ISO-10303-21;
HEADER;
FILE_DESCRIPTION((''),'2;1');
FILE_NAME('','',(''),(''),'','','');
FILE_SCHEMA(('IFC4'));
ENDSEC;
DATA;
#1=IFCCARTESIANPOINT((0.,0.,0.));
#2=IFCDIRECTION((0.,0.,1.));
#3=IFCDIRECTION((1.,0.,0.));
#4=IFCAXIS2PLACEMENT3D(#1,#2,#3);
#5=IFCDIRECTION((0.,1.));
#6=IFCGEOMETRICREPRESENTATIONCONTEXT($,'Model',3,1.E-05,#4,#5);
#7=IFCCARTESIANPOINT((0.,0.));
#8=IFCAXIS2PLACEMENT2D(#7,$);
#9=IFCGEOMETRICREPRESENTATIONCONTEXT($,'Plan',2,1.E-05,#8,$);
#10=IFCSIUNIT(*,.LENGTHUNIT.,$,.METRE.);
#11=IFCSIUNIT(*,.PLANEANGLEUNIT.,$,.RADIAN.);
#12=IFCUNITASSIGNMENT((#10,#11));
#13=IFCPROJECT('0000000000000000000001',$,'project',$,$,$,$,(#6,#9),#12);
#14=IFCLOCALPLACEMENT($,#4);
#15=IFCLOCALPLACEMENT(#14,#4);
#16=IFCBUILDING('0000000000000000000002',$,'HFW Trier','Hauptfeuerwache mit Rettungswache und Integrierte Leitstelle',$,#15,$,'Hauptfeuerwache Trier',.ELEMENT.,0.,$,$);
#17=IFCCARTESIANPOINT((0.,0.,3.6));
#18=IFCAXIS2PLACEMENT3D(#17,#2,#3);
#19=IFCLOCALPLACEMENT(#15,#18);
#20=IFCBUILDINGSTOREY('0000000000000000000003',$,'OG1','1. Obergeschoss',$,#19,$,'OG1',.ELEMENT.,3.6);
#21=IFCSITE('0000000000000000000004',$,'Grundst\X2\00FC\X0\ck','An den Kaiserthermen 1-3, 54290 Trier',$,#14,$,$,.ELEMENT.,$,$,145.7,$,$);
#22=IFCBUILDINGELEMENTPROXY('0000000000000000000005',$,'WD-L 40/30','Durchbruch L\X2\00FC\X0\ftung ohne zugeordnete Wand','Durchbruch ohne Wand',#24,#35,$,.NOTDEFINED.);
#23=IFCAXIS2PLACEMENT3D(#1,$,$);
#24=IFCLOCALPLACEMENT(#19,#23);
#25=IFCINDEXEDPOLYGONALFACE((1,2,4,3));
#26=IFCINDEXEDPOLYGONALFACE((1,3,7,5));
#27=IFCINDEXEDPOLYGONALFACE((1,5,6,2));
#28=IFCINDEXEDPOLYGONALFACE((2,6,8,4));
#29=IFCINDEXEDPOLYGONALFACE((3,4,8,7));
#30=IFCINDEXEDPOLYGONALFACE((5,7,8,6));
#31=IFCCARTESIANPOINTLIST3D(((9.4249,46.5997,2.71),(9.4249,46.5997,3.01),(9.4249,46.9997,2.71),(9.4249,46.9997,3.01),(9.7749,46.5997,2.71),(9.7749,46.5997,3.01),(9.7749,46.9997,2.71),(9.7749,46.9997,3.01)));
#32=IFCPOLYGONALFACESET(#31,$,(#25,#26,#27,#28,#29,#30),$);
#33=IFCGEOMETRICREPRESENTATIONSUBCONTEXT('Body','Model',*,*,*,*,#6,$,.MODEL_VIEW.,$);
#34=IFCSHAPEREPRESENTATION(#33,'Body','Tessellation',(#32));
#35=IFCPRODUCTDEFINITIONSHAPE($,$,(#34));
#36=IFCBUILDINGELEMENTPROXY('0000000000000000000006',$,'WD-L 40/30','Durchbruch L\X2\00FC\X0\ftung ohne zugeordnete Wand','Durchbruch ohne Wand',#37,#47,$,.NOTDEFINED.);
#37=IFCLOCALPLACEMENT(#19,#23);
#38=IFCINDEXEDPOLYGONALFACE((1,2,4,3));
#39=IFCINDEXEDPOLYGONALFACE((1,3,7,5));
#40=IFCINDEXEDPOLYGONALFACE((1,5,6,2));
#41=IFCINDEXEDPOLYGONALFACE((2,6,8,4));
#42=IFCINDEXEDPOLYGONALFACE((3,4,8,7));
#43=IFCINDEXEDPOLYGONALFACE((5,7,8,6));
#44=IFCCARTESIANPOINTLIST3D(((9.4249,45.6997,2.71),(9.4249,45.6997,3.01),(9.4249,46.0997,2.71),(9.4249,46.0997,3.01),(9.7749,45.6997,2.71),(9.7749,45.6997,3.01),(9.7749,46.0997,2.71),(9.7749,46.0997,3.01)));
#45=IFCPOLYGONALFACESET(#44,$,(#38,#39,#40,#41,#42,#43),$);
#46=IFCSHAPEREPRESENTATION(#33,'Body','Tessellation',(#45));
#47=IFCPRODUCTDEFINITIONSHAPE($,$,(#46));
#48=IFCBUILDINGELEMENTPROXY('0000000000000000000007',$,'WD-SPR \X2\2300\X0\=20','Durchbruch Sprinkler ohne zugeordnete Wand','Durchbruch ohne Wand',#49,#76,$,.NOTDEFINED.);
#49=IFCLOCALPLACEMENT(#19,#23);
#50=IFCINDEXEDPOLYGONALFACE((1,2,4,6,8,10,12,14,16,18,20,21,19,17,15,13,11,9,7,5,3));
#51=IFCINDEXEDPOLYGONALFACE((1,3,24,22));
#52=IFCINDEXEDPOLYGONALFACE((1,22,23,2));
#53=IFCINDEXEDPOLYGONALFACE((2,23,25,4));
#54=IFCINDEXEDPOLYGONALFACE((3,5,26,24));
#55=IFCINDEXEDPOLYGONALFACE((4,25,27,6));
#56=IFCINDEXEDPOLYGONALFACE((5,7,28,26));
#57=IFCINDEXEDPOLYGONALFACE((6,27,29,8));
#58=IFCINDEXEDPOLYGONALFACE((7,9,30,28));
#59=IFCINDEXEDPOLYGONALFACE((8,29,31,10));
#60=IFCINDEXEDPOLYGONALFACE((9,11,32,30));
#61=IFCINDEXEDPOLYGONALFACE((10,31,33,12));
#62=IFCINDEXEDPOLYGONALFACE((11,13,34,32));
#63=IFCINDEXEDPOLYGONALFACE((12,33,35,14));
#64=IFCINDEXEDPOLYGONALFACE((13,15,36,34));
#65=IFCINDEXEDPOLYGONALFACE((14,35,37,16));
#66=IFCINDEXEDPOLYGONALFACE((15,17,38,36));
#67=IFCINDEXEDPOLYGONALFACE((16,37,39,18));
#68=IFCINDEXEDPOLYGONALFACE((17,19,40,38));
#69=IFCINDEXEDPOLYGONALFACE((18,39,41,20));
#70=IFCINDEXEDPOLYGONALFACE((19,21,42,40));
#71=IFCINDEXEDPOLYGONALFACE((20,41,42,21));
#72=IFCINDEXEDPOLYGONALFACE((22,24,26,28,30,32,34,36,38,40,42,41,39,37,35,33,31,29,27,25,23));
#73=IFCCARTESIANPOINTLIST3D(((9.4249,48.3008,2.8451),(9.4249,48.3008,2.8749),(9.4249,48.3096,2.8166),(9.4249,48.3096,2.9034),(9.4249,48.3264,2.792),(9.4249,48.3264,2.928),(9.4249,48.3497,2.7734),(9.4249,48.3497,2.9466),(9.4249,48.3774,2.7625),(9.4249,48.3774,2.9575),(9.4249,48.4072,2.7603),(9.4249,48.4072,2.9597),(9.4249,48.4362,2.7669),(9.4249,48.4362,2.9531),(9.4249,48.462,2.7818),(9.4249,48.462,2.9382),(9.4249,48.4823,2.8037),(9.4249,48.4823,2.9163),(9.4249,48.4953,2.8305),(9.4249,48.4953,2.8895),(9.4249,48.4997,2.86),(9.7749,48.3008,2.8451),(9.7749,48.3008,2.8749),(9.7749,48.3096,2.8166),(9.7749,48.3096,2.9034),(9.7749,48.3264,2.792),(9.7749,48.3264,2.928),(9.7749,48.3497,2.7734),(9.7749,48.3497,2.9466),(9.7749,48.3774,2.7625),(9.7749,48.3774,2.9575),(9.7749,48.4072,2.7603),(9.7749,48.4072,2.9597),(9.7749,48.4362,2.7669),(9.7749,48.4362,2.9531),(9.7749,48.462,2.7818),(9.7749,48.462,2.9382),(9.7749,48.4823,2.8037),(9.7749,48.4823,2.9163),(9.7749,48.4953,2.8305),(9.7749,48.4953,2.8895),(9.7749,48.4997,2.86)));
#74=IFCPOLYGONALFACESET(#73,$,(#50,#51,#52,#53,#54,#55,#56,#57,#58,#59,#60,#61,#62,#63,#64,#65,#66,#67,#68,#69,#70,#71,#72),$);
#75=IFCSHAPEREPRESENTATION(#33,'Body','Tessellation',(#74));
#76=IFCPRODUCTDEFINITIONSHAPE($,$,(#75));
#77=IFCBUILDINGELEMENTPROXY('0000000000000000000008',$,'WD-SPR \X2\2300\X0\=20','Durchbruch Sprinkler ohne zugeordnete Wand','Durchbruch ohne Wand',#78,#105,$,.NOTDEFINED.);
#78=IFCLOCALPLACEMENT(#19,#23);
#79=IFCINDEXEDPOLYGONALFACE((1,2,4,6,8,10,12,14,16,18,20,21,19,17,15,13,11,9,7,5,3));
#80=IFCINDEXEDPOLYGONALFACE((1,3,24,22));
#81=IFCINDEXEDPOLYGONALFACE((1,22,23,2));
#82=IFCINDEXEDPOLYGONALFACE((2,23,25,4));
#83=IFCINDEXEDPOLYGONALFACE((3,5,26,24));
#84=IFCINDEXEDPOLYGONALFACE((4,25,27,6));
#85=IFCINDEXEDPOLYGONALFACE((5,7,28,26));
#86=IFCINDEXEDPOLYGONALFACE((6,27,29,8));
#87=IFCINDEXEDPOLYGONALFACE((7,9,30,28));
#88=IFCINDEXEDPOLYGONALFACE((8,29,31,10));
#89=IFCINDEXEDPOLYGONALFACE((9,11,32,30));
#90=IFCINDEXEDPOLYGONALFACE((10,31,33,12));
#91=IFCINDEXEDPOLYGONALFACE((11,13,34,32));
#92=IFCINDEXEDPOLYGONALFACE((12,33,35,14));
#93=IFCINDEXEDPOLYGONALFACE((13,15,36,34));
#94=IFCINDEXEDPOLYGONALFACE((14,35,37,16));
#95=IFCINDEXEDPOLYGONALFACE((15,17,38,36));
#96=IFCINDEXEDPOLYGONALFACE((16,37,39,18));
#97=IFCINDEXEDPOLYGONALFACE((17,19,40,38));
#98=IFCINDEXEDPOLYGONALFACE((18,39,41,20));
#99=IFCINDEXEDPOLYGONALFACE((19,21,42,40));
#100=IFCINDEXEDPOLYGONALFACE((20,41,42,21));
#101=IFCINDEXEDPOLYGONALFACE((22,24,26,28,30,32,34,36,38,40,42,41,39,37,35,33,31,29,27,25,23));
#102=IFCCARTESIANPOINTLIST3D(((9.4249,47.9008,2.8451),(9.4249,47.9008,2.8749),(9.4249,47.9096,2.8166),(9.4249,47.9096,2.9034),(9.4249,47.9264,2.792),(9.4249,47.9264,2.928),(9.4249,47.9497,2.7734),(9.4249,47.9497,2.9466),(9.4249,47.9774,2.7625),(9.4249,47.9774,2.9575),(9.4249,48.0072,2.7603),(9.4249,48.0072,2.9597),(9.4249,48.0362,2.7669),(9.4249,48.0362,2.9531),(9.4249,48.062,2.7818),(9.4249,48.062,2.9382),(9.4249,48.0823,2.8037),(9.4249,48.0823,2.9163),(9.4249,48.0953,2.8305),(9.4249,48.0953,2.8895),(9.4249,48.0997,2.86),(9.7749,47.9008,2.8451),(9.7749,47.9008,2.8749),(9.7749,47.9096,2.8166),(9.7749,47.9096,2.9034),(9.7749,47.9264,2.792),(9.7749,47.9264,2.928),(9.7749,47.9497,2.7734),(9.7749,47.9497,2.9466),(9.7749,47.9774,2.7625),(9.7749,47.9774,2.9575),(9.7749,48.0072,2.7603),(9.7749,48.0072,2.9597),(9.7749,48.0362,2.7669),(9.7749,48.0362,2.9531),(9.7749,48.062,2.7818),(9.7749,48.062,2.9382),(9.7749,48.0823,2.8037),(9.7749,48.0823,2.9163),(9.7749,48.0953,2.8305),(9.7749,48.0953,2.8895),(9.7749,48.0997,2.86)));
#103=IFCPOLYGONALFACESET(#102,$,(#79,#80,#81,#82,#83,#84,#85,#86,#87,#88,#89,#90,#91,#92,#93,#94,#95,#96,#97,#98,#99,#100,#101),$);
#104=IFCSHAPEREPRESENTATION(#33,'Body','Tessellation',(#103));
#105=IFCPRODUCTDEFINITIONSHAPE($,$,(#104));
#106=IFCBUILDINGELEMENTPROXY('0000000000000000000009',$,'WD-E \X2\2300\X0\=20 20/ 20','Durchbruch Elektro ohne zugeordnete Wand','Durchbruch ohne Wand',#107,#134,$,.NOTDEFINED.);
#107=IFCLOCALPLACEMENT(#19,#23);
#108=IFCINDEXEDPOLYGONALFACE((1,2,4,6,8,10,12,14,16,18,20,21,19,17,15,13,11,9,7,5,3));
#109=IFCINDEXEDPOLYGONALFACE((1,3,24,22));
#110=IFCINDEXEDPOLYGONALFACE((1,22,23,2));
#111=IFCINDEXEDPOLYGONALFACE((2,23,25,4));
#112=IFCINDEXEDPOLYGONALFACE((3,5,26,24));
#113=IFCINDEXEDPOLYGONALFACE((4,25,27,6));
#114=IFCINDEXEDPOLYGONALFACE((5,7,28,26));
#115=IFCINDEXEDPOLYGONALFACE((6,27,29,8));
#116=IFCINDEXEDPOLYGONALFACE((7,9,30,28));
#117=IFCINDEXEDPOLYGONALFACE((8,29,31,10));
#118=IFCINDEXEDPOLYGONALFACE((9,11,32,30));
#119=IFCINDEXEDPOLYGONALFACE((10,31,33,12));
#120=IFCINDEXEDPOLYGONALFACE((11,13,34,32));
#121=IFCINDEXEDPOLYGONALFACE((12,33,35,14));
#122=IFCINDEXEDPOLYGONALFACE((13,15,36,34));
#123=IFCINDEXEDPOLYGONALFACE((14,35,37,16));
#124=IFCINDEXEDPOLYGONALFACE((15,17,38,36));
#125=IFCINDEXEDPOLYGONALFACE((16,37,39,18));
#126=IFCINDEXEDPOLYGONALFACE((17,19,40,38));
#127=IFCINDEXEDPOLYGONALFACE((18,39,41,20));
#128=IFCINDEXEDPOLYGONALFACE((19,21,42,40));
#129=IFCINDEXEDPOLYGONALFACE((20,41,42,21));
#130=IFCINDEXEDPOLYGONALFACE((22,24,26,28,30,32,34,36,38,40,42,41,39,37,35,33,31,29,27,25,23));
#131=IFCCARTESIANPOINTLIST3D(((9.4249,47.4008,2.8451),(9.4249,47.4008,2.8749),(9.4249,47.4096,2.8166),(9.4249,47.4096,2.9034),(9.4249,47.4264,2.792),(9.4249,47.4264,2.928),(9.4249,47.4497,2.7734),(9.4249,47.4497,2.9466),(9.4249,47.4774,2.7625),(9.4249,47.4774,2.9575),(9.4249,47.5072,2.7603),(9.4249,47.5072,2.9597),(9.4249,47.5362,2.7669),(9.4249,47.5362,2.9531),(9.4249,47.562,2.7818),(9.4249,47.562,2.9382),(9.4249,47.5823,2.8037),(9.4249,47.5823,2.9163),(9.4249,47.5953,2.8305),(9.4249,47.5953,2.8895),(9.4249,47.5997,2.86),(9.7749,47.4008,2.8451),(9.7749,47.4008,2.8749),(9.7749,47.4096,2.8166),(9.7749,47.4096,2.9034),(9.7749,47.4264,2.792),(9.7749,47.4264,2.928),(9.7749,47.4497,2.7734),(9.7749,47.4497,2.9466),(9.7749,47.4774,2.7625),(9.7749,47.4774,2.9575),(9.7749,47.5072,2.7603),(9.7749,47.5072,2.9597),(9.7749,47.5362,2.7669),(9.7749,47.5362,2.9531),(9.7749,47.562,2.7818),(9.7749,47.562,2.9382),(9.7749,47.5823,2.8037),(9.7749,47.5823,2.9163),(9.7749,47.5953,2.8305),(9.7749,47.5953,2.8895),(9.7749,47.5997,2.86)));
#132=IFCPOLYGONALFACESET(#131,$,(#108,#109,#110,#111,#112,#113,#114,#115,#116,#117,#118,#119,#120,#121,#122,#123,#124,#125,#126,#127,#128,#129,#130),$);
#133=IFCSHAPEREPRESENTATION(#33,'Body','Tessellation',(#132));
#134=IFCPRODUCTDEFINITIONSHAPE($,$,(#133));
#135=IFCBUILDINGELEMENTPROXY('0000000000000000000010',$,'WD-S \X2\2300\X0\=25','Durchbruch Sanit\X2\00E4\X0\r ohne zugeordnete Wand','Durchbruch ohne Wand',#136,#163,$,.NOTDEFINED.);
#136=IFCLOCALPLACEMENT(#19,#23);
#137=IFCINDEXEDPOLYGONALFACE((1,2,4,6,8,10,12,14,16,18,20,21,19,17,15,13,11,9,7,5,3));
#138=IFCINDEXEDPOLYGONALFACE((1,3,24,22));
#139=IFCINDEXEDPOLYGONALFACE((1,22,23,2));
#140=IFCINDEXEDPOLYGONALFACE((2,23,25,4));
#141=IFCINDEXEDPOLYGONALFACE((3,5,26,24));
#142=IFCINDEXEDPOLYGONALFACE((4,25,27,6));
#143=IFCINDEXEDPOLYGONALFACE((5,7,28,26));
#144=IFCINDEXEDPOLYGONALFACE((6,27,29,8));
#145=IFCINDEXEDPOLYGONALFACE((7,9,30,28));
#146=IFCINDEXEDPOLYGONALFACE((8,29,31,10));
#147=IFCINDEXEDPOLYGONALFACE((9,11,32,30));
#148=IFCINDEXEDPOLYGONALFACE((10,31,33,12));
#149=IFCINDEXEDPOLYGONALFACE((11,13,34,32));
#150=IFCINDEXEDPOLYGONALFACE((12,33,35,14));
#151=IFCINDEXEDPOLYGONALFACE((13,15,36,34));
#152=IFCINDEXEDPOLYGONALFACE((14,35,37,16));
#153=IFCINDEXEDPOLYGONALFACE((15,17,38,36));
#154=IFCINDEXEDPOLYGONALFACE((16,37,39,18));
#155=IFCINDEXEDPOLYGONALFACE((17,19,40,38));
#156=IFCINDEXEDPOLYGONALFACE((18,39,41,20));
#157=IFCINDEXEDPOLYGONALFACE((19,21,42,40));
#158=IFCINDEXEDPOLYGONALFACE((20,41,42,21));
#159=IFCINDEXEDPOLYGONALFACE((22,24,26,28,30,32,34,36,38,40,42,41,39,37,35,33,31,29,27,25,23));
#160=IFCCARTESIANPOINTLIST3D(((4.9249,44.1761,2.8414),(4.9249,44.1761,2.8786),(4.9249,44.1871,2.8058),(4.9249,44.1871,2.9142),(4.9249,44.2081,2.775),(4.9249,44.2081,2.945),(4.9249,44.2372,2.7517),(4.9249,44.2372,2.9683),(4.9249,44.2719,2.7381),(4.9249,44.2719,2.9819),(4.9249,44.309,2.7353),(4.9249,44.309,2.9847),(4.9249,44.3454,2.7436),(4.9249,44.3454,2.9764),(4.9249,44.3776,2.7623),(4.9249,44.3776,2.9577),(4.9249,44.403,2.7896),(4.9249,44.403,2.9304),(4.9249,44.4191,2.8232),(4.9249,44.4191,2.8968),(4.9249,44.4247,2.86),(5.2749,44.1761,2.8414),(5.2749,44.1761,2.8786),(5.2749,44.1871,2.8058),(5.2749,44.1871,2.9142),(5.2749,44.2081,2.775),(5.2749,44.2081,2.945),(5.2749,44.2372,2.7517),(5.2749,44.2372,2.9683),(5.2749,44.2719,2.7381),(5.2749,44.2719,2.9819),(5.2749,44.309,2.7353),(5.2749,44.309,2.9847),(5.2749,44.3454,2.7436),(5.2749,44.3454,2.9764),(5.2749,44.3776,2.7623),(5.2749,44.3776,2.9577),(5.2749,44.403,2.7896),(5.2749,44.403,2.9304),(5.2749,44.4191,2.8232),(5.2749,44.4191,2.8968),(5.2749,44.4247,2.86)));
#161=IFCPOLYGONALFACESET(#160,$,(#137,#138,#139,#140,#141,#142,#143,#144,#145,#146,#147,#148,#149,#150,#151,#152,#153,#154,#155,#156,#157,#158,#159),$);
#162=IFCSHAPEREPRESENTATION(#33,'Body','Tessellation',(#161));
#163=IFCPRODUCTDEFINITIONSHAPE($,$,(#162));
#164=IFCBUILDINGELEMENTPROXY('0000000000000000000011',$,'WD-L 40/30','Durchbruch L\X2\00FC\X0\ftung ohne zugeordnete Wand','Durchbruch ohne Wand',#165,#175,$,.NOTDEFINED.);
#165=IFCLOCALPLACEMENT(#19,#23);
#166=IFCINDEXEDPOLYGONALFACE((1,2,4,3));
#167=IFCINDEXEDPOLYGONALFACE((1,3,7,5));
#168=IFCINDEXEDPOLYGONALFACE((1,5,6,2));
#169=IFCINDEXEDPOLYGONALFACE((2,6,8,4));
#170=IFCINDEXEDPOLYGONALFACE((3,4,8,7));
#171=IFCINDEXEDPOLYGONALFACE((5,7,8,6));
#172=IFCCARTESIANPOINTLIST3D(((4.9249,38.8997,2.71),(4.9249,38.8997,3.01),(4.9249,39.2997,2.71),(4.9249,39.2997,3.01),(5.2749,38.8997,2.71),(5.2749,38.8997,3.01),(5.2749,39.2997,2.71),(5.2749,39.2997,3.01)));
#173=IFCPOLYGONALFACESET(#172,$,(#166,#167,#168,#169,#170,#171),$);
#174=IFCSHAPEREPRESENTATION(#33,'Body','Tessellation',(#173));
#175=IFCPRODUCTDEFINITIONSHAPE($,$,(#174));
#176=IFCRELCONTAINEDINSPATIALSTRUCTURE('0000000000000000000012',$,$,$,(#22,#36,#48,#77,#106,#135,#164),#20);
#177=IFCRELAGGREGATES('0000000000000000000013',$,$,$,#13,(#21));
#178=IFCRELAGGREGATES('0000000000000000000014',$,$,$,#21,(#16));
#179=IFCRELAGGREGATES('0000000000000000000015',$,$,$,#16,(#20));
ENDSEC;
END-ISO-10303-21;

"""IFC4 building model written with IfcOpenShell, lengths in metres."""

from ifc_helpers import new_model, si_unit, direction, frame, origin_with_axes, origin_2d, place, context, subcontext, project, spatial, rectangle, circle, extrude, element, save


model = new_model("IFC4")

# Units and contexts
model_context = context("Model", 3, precision=1e-05, world=origin_with_axes(), true_north=direction((0.0, 1.0)))
plan_context = context("Plan", 2, precision=1e-05, world=origin_2d())
body_context = subcontext(model_context, "Body", "Model", "MODEL_VIEW")
ifc_project = project(units=[si_unit("LENGTHUNIT", "METRE"), si_unit("PLANEANGLEUNIT", "RADIAN")], contexts=[model_context, plan_context])

# Site, building, storey
site_placement = place(None, origin_with_axes())
site = spatial("IfcSite", under=ifc_project, at=site_placement, Name="Grundstück", Description="An den Kaiserthermen 1-3, 54290 Trier", CompositionType="ELEMENT", RefElevation=145.7)
building_placement = place(site_placement, origin_with_axes())
building = spatial("IfcBuilding", under=site, at=building_placement, Name="HFW Trier", Description="Hauptfeuerwache mit Rettungswache und Integrierte Leitstelle", LongName="Hauptfeuerwache Trier", CompositionType="ELEMENT", ElevationOfRefHeight=0.0)
storey_placement = place(building_placement, frame((0.0, 0.0, 3.6), z_axis=(0.0, 0.0, 1.0), x_axis=(1.0, 0.0, 0.0)))
storey = spatial("IfcBuildingStorey", under=building, at=storey_placement, Name="OG1", Description="1. Obergeschoss", LongName="OG1", CompositionType="ELEMENT", Elevation=3.6)

# Building element proxies
for number, where, z_axis, x_axis, name in (
    (1, (9.5999, 46.7997, 2.71), (0.0, 0.0, 1.0), (0.0, 1.0, 0.0), "WD-L 40/30"),
    (2, (9.5999, 45.8997, 2.71), (0.0, 0.0, 1.0), (0.0, 1.0, 0.0), "WD-L 40/30"),
):
    element("IfcBuildingElementProxy", number, at=place(storey_placement, frame(where, z_axis=z_axis, x_axis=x_axis)), inside=storey, Name=name, Description="Durchbruch Lüftung ohne zugeordnete Wand", ObjectType="Durchbruch ohne Wand", PredefinedType="NOTDEFINED", context=body_context, shape_type="SweptSolid", body=[
        extrude(rectangle(XDim=0.4, YDim=0.35, at=origin_2d()), origin_with_axes(), (0.0, 0.0, 1.0), 0.3),
    ])
for number, where, z_axis, x_axis, name, description in (
    (3, (9.5999, 48.3997, 2.76), (0.0, 0.0, 1.0), (0.0, 1.0, 0.0), "WD-SPR ⌀=20", "Durchbruch Sprinkler ohne zugeordnete Wand"),
    (4, (9.5999, 47.9997, 2.76), (0.0, 0.0, 1.0), (0.0, 1.0, 0.0), "WD-SPR ⌀=20", "Durchbruch Sprinkler ohne zugeordnete Wand"),
    (5, (9.5999, 47.4997, 2.76), (0.0, 0.0, 1.0), (0.0, 1.0, 0.0), "WD-E ⌀=20 20/ 20", "Durchbruch Elektro ohne zugeordnete Wand"),
):
    element("IfcBuildingElementProxy", number, at=place(storey_placement, frame(where, z_axis=z_axis, x_axis=x_axis)), inside=storey, Name=name, Description=description, ObjectType="Durchbruch ohne Wand", PredefinedType="NOTDEFINED", context=body_context, shape_type="SweptSolid", body=[
        extrude(circle(Radius=0.1, at=origin_2d()), frame((0.0, -0.175, 0.1), z_axis=(0.0, 1.0, 0.0), x_axis=(1.0, 0.0, 0.0)), (0.0, 0.0, 1.0), 0.35),
    ])
proxy_1_placement = place(storey_placement, frame((5.0999, 44.2997, 2.735), z_axis=(0.0, 0.0, 1.0), x_axis=(0.0, 1.0, 0.0)))
element("IfcBuildingElementProxy", 6, at=proxy_1_placement, inside=storey, Name="WD-S ⌀=25", Description="Durchbruch Sanitär ohne zugeordnete Wand", ObjectType="Durchbruch ohne Wand", PredefinedType="NOTDEFINED", context=body_context, shape_type="SweptSolid", body=[
    extrude(circle(Radius=0.125, at=origin_2d()), frame((0.0, -0.175, 0.125), z_axis=(0.0, 1.0, 0.0), x_axis=(1.0, 0.0, 0.0)), (0.0, 0.0, 1.0), 0.35),
])
proxy_2_placement = place(storey_placement, frame((5.0999, 39.0997, 2.71), z_axis=(0.0, 0.0, 1.0), x_axis=(0.0, 1.0, 0.0)))
element("IfcBuildingElementProxy", 7, at=proxy_2_placement, inside=storey, Name="WD-L 40/30", Description="Durchbruch Lüftung ohne zugeordnete Wand", ObjectType="Durchbruch ohne Wand", PredefinedType="NOTDEFINED", context=body_context, shape_type="SweptSolid", body=[
    extrude(rectangle(XDim=0.4, YDim=0.35, at=origin_2d()), origin_with_axes(), (0.0, 0.0, 1.0), 0.3),
])

save(model, "model.ifc")
